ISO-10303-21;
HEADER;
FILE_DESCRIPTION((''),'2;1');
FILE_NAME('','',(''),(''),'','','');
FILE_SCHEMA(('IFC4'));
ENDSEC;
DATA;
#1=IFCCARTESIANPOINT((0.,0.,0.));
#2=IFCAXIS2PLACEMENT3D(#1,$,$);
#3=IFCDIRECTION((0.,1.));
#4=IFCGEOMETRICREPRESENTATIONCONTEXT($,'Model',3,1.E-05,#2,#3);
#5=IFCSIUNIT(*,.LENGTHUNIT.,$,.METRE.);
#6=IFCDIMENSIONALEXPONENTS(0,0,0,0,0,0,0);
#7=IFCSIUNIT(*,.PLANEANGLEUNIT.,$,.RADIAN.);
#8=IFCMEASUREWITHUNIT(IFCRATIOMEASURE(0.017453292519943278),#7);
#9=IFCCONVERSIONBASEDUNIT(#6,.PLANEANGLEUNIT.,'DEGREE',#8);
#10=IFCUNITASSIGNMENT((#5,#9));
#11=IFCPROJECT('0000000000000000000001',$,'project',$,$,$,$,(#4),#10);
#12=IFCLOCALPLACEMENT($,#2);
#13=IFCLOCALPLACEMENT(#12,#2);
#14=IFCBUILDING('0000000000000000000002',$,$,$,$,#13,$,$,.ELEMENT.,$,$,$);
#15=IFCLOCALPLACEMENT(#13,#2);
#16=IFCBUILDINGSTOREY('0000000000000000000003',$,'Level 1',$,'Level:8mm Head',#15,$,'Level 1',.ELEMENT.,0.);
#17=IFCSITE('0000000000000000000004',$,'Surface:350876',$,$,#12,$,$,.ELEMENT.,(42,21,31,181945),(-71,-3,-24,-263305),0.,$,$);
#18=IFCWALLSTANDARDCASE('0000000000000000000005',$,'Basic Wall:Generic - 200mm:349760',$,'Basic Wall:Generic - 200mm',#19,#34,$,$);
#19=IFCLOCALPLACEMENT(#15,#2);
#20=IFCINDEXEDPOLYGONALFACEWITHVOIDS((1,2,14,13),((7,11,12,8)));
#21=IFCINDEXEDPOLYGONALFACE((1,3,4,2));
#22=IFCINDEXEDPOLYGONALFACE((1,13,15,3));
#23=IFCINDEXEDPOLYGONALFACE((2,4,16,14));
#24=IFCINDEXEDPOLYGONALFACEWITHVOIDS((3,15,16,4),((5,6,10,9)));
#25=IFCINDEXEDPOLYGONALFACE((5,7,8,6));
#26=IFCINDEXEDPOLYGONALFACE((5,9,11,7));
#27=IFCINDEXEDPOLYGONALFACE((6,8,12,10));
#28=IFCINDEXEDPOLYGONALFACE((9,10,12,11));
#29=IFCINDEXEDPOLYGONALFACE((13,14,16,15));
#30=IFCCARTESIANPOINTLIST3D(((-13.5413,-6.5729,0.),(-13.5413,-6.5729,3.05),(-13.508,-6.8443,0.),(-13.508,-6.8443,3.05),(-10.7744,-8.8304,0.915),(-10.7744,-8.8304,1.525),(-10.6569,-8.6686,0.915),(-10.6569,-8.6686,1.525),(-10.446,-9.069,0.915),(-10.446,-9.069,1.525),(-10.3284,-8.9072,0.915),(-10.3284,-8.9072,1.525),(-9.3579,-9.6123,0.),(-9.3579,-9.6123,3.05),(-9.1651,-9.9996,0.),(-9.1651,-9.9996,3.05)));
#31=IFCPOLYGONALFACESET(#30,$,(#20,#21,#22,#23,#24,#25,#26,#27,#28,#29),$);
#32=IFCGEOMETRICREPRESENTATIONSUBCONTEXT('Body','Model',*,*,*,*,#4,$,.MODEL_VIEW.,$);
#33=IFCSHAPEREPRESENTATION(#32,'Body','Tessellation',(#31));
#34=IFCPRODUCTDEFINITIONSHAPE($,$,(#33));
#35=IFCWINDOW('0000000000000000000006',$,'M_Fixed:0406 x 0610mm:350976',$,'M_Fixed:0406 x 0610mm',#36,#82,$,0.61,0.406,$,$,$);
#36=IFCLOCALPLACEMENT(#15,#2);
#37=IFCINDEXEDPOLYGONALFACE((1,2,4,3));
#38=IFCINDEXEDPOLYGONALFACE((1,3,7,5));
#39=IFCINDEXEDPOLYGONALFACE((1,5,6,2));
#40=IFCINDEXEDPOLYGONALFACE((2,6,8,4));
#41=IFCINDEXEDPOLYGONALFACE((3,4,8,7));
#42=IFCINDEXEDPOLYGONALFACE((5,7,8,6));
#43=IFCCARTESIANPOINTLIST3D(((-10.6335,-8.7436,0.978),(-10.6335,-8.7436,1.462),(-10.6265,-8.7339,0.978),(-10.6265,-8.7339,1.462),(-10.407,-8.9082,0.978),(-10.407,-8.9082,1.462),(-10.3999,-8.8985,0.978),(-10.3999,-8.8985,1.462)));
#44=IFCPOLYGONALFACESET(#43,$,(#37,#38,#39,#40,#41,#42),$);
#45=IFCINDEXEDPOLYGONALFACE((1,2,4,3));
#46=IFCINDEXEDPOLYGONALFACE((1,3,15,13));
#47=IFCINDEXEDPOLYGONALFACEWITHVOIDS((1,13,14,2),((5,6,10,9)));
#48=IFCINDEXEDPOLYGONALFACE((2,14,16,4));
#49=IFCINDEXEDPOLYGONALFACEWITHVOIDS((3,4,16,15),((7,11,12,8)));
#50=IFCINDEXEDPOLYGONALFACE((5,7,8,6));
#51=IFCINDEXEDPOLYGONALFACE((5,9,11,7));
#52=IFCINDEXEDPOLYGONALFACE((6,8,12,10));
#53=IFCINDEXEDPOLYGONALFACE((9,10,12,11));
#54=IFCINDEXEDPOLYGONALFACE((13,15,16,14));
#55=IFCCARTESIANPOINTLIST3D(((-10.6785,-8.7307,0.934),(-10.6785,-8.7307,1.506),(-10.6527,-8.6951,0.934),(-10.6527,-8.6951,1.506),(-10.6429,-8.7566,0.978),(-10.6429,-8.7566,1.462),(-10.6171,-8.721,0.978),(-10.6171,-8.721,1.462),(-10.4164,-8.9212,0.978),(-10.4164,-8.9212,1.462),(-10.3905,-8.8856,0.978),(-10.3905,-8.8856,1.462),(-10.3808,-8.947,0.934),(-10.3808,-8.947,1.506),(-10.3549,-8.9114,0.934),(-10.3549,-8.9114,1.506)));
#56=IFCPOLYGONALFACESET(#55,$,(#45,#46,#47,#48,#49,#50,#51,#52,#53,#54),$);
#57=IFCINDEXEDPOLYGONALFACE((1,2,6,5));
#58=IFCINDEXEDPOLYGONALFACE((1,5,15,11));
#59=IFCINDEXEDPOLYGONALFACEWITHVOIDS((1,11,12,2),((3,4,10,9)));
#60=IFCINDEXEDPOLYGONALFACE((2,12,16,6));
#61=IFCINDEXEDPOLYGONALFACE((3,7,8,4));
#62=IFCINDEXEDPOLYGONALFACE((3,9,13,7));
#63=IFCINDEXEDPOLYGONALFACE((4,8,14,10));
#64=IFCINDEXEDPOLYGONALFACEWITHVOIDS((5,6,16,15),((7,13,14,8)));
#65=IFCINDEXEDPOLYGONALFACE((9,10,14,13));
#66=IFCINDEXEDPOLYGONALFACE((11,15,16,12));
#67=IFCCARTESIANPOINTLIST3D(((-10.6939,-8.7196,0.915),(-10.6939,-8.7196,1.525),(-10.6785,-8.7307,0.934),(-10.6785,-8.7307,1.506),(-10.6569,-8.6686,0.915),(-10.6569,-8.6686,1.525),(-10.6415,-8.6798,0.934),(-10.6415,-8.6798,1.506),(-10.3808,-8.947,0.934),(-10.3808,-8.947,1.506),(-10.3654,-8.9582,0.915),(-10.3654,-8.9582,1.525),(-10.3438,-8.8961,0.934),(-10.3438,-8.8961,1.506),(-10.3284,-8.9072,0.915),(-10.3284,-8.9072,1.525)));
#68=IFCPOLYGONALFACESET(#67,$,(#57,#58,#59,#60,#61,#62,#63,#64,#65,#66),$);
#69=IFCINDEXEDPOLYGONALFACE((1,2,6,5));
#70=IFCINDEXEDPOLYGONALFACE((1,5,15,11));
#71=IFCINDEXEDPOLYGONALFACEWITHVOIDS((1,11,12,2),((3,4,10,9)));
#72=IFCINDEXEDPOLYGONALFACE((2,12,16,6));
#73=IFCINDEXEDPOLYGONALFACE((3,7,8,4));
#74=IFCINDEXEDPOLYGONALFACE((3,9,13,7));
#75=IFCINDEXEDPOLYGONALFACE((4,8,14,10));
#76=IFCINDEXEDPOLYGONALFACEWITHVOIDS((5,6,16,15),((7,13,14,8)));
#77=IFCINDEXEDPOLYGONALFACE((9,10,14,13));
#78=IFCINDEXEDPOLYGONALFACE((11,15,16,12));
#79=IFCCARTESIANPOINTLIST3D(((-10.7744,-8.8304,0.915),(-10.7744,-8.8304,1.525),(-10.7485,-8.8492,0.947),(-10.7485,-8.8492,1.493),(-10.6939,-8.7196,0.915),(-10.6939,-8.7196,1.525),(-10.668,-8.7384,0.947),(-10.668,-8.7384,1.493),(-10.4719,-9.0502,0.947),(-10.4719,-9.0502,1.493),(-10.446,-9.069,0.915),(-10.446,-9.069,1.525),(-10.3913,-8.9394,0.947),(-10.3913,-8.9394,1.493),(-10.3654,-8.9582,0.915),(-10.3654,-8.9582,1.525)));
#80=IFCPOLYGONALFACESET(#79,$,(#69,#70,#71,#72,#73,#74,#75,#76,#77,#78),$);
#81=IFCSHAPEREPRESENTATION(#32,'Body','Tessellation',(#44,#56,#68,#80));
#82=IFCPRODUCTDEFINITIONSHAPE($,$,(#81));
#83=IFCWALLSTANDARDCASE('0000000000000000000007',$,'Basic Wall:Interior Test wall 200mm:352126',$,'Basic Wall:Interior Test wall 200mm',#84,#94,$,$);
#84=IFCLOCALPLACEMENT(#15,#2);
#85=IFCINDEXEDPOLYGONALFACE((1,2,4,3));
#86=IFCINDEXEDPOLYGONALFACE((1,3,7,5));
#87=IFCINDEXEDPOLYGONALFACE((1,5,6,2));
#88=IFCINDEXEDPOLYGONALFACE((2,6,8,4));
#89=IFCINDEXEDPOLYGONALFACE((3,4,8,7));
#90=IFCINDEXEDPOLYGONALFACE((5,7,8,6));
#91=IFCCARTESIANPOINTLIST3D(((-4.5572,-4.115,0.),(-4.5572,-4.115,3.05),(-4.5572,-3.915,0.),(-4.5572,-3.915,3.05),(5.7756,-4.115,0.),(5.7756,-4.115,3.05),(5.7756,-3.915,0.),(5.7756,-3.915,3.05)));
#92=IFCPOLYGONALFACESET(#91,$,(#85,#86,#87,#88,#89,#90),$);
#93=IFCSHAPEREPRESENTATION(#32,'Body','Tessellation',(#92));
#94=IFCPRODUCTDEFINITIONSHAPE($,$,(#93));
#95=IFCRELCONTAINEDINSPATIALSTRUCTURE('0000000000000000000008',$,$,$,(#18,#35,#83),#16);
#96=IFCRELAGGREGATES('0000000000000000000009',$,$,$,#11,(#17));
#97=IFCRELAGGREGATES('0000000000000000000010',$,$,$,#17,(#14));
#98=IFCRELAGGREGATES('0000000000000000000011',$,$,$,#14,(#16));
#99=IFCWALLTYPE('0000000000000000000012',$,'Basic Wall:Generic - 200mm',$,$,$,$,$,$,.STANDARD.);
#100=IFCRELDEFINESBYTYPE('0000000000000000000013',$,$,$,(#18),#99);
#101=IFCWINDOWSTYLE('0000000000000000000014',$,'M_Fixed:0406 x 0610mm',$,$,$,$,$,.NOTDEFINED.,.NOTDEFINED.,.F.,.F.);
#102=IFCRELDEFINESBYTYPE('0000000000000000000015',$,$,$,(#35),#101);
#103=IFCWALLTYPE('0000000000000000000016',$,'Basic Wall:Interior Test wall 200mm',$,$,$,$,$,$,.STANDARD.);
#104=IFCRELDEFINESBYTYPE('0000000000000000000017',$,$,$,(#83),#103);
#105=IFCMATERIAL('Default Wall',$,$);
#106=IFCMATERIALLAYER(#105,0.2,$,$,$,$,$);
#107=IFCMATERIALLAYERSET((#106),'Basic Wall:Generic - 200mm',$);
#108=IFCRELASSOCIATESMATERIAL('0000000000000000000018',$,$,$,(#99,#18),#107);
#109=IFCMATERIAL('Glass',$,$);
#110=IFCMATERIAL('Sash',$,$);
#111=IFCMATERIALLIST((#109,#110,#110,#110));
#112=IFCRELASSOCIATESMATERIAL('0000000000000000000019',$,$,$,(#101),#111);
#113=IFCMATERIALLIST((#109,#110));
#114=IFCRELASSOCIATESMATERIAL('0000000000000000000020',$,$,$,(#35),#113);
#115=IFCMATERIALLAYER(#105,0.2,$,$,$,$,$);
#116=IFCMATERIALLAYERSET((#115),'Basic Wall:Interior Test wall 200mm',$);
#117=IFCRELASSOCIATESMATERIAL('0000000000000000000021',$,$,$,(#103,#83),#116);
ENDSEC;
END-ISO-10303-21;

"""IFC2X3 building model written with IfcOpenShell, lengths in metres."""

from ifc_helpers import new_model, entity, si_unit, converted_unit, direction, frame, frame_2d, origin, place, context, subcontext, project, spatial, polyline, rectangle, outline, extrude, clip, bounded_halfspace, source, transform, mapped, material, material_list, layer, layer_set, layer_usage, type_object, type_shapes, element, fill, save


model = new_model("IFC2X3")

# Units and contexts
model_context = context("Model", 3, precision=1e-05, world=origin(), true_north=direction((0.0, 1.0)))
body_context = subcontext(model_context, "Body", "Model", "MODEL_VIEW")
ifc_project = project(units=[si_unit("LENGTHUNIT", "METRE"), converted_unit("PLANEANGLEUNIT", "DEGREE", entity("IfcRatioMeasure", 0.017453292519943278), si_unit("PLANEANGLEUNIT", "RADIAN"), dimensions=[0, 0, 0, 0, 0, 0, 0])], contexts=[model_context])

# Site, building, storey
site_placement = place(None, origin())
site = spatial("IfcSite", under=ifc_project, at=site_placement, Name="Surface:350876", CompositionType="ELEMENT", RefLatitude=(42, 21, 31, 181945), RefLongitude=(-71, -3, -24, -263305), RefElevation=0.0)
building_placement = place(site_placement, origin())
building = spatial("IfcBuilding", under=site, at=building_placement, CompositionType="ELEMENT")
storey_placement = place(building_placement, origin())
storey = spatial("IfcBuildingStorey", under=building, at=storey_placement, Name="Level 1", ObjectType="Level:8mm Head", LongName="Level 1", CompositionType="ELEMENT", Elevation=0.0)

# Wall, opening, window
ifc_material_1 = material(Name="Default Wall")
ifc_layer_1 = layer(ifc_material_1, 0.2)
ifc_layer_set_1 = layer_set([ifc_layer_1], Name="Basic Wall:Generic - 200mm")
ifc_layer_usage_1 = layer_usage(ifc_layer_set_1, "AXIS2", "NEGATIVE", 0.1)
wall_type_1 = type_object("IfcWallType", Name="Basic Wall:Generic - 200mm", PredefinedType="STANDARD", material=ifc_layer_set_1)
wall_1_placement = place(storey_placement, frame((-13.6001, -6.6538, 0.0), z_axis=(0.0, 0.0, 1.0), x_axis=(0.809017, -0.587785, 0.0)))
wall_1 = element("IfcWallStandardCase", 1, at=wall_1_placement, inside=storey, type_object=wall_type_1, material=ifc_layer_usage_1, Name="Basic Wall:Generic - 200mm:349760", ObjectType="Basic Wall:Generic - 200mm", context=body_context, shape_type="SweptSolid", body=[
    extrude(outline(polyline([(5.5546, -0.1), (5.171, 0.1), (2.0178, 0.1), (1.8098, 0.1), (0.0, 0.1), (0.1865, -0.1), (5.122, -0.1), (5.5546, -0.1)])), origin(), (0.0, 0.0, 1.0), 3.05),
])
opening_1_placement = place(wall_1_placement, frame((3.5654, -0.1, 0.915)))
opening_1 = element("IfcOpeningElement", 2, at=opening_1_placement, cuts=wall_1, ObjectType="Opening", context=body_context, shape_type="SweptSolid", body=[
    extrude(rectangle(XDim=0.61, YDim=0.406, at=frame_2d((0.305, 0.203), x_axis=(1.0, 0.0))), frame((0.0, 0.0, 0.0), z_axis=(0.0, 1.0, 0.0), x_axis=(0.0, 0.0, 1.0)), (0.0, 0.0, 1.0), 0.2),
])
ifc_material_2 = material(Name="Glass")
ifc_material_3 = material(Name="Sash")
ifc_material_list_1 = material_list([ifc_material_2, ifc_material_3])
ifc_material_list_2 = material_list([ifc_material_2, ifc_material_3, ifc_material_3, ifc_material_3])
window_style = type_object("IfcWindowStyle", Name="M_Fixed:0406 x 0610mm", ConstructionType="NOTDEFINED", OperationType="NOTDEFINED", ParameterTakesPrecedence=False, Sizeable=False, material=ifc_material_list_2)
shared_shape = source(origin(), body_context, "Body", "SweptSolid", [
    extrude(rectangle(XDim=0.012, YDim=0.28, at=frame_2d((0.0, 0.0), x_axis=(1.0, 0.0))), frame((0.203, 0.159, 0.063), z_axis=(0.0, 0.0, 1.0), x_axis=(0.0, -1.0, 0.0)), (0.0, 0.0, 1.0), 0.484),
    extrude(outline(polyline([(-0.184, -0.286), (0.184, -0.286), (0.184, 0.286), (-0.184, 0.286), (-0.184, -0.286)]), holes=[polyline([(-0.14, -0.242), (-0.14, 0.242), (0.14, 0.242), (0.14, -0.242), (-0.14, -0.242)])]), frame((0.203, 0.137, 0.305), z_axis=(0.0, 1.0, 0.0), x_axis=(1.0, 0.0, 0.0)), (0.0, 0.0, 1.0), 0.044),
    extrude(outline(polyline([(-0.203, -0.305), (0.203, -0.305), (0.203, 0.305), (-0.203, 0.305), (-0.203, -0.305)]), holes=[polyline([(-0.184, -0.286), (-0.184, 0.286), (0.184, 0.286), (0.184, -0.286), (-0.184, -0.286)])]), frame((0.203, 0.137, 0.305), z_axis=(0.0, 1.0, 0.0), x_axis=(1.0, 0.0, 0.0)), (0.0, 0.0, 1.0), 0.063),
    extrude(outline(polyline([(-0.203, -0.305), (0.203, -0.305), (0.203, 0.305), (-0.203, 0.305), (-0.203, -0.305)]), holes=[polyline([(-0.171, -0.273), (-0.171, 0.273), (0.171, 0.273), (0.171, -0.273), (-0.171, -0.273)])]), frame((0.203, 0.0, 0.305), z_axis=(0.0, 1.0, 0.0), x_axis=(1.0, 0.0, 0.0)), (0.0, 0.0, 1.0), 0.137),
])
type_shapes(window_style, [shared_shape])
window_1_placement = place(opening_1_placement, origin())
window_1 = element("IfcWindow", 3, at=window_1_placement, inside=storey, type_object=window_style, material=ifc_material_list_1, Name="M_Fixed:0406 x 0610mm:350976", ObjectType="M_Fixed:0406 x 0610mm", OverallHeight=0.61, OverallWidth=0.406, context=body_context, shape_type="MappedRepresentation", body=[
    mapped(shared_shape, transform((0.0, 0.0, 0.0), scale=1.0)),
])
fill(opening_1, window_1)

# Wall
ifc_layer_2 = layer(ifc_material_1, 0.2)
ifc_layer_set_2 = layer_set([ifc_layer_2], Name="Basic Wall:Interior Test wall 200mm")
ifc_layer_usage_2 = layer_usage(ifc_layer_set_2, "AXIS2", "NEGATIVE", 0.1)
wall_type_2 = type_object("IfcWallType", Name="Basic Wall:Interior Test wall 200mm", PredefinedType="STANDARD", material=ifc_layer_set_2)
wall_2_placement = place(storey_placement, frame((-4.5572, -4.015, 0.0)))
element("IfcWallStandardCase", 4, at=wall_2_placement, inside=storey, type_object=wall_type_2, material=ifc_layer_usage_2, Name="Basic Wall:Interior Test wall 200mm:352126", ObjectType="Basic Wall:Interior Test wall 200mm", context=body_context, shape_type="Clipping", body=[
    clip(extrude(rectangle(XDim=10.3328, YDim=0.2, at=frame_2d((5.1664, 0.0), x_axis=(-1.0, 0.0))), origin(), (0.0, 0.0, 1.0), 3.05), bounded_halfspace(frame((0.0, -0.1, 3.05), z_axis=(0.0, 0.0, -1.0), x_axis=(0.224951, 0.97437, 0.0)), True, frame((0.0, -0.1, 3.05)), polyline([(0.0, 0.0), (10.3328, 0.0), (10.3328, 0.2), (0.0, 0.2), (0.0, 0.0)]))),
])

save(model, "model.ifc")
